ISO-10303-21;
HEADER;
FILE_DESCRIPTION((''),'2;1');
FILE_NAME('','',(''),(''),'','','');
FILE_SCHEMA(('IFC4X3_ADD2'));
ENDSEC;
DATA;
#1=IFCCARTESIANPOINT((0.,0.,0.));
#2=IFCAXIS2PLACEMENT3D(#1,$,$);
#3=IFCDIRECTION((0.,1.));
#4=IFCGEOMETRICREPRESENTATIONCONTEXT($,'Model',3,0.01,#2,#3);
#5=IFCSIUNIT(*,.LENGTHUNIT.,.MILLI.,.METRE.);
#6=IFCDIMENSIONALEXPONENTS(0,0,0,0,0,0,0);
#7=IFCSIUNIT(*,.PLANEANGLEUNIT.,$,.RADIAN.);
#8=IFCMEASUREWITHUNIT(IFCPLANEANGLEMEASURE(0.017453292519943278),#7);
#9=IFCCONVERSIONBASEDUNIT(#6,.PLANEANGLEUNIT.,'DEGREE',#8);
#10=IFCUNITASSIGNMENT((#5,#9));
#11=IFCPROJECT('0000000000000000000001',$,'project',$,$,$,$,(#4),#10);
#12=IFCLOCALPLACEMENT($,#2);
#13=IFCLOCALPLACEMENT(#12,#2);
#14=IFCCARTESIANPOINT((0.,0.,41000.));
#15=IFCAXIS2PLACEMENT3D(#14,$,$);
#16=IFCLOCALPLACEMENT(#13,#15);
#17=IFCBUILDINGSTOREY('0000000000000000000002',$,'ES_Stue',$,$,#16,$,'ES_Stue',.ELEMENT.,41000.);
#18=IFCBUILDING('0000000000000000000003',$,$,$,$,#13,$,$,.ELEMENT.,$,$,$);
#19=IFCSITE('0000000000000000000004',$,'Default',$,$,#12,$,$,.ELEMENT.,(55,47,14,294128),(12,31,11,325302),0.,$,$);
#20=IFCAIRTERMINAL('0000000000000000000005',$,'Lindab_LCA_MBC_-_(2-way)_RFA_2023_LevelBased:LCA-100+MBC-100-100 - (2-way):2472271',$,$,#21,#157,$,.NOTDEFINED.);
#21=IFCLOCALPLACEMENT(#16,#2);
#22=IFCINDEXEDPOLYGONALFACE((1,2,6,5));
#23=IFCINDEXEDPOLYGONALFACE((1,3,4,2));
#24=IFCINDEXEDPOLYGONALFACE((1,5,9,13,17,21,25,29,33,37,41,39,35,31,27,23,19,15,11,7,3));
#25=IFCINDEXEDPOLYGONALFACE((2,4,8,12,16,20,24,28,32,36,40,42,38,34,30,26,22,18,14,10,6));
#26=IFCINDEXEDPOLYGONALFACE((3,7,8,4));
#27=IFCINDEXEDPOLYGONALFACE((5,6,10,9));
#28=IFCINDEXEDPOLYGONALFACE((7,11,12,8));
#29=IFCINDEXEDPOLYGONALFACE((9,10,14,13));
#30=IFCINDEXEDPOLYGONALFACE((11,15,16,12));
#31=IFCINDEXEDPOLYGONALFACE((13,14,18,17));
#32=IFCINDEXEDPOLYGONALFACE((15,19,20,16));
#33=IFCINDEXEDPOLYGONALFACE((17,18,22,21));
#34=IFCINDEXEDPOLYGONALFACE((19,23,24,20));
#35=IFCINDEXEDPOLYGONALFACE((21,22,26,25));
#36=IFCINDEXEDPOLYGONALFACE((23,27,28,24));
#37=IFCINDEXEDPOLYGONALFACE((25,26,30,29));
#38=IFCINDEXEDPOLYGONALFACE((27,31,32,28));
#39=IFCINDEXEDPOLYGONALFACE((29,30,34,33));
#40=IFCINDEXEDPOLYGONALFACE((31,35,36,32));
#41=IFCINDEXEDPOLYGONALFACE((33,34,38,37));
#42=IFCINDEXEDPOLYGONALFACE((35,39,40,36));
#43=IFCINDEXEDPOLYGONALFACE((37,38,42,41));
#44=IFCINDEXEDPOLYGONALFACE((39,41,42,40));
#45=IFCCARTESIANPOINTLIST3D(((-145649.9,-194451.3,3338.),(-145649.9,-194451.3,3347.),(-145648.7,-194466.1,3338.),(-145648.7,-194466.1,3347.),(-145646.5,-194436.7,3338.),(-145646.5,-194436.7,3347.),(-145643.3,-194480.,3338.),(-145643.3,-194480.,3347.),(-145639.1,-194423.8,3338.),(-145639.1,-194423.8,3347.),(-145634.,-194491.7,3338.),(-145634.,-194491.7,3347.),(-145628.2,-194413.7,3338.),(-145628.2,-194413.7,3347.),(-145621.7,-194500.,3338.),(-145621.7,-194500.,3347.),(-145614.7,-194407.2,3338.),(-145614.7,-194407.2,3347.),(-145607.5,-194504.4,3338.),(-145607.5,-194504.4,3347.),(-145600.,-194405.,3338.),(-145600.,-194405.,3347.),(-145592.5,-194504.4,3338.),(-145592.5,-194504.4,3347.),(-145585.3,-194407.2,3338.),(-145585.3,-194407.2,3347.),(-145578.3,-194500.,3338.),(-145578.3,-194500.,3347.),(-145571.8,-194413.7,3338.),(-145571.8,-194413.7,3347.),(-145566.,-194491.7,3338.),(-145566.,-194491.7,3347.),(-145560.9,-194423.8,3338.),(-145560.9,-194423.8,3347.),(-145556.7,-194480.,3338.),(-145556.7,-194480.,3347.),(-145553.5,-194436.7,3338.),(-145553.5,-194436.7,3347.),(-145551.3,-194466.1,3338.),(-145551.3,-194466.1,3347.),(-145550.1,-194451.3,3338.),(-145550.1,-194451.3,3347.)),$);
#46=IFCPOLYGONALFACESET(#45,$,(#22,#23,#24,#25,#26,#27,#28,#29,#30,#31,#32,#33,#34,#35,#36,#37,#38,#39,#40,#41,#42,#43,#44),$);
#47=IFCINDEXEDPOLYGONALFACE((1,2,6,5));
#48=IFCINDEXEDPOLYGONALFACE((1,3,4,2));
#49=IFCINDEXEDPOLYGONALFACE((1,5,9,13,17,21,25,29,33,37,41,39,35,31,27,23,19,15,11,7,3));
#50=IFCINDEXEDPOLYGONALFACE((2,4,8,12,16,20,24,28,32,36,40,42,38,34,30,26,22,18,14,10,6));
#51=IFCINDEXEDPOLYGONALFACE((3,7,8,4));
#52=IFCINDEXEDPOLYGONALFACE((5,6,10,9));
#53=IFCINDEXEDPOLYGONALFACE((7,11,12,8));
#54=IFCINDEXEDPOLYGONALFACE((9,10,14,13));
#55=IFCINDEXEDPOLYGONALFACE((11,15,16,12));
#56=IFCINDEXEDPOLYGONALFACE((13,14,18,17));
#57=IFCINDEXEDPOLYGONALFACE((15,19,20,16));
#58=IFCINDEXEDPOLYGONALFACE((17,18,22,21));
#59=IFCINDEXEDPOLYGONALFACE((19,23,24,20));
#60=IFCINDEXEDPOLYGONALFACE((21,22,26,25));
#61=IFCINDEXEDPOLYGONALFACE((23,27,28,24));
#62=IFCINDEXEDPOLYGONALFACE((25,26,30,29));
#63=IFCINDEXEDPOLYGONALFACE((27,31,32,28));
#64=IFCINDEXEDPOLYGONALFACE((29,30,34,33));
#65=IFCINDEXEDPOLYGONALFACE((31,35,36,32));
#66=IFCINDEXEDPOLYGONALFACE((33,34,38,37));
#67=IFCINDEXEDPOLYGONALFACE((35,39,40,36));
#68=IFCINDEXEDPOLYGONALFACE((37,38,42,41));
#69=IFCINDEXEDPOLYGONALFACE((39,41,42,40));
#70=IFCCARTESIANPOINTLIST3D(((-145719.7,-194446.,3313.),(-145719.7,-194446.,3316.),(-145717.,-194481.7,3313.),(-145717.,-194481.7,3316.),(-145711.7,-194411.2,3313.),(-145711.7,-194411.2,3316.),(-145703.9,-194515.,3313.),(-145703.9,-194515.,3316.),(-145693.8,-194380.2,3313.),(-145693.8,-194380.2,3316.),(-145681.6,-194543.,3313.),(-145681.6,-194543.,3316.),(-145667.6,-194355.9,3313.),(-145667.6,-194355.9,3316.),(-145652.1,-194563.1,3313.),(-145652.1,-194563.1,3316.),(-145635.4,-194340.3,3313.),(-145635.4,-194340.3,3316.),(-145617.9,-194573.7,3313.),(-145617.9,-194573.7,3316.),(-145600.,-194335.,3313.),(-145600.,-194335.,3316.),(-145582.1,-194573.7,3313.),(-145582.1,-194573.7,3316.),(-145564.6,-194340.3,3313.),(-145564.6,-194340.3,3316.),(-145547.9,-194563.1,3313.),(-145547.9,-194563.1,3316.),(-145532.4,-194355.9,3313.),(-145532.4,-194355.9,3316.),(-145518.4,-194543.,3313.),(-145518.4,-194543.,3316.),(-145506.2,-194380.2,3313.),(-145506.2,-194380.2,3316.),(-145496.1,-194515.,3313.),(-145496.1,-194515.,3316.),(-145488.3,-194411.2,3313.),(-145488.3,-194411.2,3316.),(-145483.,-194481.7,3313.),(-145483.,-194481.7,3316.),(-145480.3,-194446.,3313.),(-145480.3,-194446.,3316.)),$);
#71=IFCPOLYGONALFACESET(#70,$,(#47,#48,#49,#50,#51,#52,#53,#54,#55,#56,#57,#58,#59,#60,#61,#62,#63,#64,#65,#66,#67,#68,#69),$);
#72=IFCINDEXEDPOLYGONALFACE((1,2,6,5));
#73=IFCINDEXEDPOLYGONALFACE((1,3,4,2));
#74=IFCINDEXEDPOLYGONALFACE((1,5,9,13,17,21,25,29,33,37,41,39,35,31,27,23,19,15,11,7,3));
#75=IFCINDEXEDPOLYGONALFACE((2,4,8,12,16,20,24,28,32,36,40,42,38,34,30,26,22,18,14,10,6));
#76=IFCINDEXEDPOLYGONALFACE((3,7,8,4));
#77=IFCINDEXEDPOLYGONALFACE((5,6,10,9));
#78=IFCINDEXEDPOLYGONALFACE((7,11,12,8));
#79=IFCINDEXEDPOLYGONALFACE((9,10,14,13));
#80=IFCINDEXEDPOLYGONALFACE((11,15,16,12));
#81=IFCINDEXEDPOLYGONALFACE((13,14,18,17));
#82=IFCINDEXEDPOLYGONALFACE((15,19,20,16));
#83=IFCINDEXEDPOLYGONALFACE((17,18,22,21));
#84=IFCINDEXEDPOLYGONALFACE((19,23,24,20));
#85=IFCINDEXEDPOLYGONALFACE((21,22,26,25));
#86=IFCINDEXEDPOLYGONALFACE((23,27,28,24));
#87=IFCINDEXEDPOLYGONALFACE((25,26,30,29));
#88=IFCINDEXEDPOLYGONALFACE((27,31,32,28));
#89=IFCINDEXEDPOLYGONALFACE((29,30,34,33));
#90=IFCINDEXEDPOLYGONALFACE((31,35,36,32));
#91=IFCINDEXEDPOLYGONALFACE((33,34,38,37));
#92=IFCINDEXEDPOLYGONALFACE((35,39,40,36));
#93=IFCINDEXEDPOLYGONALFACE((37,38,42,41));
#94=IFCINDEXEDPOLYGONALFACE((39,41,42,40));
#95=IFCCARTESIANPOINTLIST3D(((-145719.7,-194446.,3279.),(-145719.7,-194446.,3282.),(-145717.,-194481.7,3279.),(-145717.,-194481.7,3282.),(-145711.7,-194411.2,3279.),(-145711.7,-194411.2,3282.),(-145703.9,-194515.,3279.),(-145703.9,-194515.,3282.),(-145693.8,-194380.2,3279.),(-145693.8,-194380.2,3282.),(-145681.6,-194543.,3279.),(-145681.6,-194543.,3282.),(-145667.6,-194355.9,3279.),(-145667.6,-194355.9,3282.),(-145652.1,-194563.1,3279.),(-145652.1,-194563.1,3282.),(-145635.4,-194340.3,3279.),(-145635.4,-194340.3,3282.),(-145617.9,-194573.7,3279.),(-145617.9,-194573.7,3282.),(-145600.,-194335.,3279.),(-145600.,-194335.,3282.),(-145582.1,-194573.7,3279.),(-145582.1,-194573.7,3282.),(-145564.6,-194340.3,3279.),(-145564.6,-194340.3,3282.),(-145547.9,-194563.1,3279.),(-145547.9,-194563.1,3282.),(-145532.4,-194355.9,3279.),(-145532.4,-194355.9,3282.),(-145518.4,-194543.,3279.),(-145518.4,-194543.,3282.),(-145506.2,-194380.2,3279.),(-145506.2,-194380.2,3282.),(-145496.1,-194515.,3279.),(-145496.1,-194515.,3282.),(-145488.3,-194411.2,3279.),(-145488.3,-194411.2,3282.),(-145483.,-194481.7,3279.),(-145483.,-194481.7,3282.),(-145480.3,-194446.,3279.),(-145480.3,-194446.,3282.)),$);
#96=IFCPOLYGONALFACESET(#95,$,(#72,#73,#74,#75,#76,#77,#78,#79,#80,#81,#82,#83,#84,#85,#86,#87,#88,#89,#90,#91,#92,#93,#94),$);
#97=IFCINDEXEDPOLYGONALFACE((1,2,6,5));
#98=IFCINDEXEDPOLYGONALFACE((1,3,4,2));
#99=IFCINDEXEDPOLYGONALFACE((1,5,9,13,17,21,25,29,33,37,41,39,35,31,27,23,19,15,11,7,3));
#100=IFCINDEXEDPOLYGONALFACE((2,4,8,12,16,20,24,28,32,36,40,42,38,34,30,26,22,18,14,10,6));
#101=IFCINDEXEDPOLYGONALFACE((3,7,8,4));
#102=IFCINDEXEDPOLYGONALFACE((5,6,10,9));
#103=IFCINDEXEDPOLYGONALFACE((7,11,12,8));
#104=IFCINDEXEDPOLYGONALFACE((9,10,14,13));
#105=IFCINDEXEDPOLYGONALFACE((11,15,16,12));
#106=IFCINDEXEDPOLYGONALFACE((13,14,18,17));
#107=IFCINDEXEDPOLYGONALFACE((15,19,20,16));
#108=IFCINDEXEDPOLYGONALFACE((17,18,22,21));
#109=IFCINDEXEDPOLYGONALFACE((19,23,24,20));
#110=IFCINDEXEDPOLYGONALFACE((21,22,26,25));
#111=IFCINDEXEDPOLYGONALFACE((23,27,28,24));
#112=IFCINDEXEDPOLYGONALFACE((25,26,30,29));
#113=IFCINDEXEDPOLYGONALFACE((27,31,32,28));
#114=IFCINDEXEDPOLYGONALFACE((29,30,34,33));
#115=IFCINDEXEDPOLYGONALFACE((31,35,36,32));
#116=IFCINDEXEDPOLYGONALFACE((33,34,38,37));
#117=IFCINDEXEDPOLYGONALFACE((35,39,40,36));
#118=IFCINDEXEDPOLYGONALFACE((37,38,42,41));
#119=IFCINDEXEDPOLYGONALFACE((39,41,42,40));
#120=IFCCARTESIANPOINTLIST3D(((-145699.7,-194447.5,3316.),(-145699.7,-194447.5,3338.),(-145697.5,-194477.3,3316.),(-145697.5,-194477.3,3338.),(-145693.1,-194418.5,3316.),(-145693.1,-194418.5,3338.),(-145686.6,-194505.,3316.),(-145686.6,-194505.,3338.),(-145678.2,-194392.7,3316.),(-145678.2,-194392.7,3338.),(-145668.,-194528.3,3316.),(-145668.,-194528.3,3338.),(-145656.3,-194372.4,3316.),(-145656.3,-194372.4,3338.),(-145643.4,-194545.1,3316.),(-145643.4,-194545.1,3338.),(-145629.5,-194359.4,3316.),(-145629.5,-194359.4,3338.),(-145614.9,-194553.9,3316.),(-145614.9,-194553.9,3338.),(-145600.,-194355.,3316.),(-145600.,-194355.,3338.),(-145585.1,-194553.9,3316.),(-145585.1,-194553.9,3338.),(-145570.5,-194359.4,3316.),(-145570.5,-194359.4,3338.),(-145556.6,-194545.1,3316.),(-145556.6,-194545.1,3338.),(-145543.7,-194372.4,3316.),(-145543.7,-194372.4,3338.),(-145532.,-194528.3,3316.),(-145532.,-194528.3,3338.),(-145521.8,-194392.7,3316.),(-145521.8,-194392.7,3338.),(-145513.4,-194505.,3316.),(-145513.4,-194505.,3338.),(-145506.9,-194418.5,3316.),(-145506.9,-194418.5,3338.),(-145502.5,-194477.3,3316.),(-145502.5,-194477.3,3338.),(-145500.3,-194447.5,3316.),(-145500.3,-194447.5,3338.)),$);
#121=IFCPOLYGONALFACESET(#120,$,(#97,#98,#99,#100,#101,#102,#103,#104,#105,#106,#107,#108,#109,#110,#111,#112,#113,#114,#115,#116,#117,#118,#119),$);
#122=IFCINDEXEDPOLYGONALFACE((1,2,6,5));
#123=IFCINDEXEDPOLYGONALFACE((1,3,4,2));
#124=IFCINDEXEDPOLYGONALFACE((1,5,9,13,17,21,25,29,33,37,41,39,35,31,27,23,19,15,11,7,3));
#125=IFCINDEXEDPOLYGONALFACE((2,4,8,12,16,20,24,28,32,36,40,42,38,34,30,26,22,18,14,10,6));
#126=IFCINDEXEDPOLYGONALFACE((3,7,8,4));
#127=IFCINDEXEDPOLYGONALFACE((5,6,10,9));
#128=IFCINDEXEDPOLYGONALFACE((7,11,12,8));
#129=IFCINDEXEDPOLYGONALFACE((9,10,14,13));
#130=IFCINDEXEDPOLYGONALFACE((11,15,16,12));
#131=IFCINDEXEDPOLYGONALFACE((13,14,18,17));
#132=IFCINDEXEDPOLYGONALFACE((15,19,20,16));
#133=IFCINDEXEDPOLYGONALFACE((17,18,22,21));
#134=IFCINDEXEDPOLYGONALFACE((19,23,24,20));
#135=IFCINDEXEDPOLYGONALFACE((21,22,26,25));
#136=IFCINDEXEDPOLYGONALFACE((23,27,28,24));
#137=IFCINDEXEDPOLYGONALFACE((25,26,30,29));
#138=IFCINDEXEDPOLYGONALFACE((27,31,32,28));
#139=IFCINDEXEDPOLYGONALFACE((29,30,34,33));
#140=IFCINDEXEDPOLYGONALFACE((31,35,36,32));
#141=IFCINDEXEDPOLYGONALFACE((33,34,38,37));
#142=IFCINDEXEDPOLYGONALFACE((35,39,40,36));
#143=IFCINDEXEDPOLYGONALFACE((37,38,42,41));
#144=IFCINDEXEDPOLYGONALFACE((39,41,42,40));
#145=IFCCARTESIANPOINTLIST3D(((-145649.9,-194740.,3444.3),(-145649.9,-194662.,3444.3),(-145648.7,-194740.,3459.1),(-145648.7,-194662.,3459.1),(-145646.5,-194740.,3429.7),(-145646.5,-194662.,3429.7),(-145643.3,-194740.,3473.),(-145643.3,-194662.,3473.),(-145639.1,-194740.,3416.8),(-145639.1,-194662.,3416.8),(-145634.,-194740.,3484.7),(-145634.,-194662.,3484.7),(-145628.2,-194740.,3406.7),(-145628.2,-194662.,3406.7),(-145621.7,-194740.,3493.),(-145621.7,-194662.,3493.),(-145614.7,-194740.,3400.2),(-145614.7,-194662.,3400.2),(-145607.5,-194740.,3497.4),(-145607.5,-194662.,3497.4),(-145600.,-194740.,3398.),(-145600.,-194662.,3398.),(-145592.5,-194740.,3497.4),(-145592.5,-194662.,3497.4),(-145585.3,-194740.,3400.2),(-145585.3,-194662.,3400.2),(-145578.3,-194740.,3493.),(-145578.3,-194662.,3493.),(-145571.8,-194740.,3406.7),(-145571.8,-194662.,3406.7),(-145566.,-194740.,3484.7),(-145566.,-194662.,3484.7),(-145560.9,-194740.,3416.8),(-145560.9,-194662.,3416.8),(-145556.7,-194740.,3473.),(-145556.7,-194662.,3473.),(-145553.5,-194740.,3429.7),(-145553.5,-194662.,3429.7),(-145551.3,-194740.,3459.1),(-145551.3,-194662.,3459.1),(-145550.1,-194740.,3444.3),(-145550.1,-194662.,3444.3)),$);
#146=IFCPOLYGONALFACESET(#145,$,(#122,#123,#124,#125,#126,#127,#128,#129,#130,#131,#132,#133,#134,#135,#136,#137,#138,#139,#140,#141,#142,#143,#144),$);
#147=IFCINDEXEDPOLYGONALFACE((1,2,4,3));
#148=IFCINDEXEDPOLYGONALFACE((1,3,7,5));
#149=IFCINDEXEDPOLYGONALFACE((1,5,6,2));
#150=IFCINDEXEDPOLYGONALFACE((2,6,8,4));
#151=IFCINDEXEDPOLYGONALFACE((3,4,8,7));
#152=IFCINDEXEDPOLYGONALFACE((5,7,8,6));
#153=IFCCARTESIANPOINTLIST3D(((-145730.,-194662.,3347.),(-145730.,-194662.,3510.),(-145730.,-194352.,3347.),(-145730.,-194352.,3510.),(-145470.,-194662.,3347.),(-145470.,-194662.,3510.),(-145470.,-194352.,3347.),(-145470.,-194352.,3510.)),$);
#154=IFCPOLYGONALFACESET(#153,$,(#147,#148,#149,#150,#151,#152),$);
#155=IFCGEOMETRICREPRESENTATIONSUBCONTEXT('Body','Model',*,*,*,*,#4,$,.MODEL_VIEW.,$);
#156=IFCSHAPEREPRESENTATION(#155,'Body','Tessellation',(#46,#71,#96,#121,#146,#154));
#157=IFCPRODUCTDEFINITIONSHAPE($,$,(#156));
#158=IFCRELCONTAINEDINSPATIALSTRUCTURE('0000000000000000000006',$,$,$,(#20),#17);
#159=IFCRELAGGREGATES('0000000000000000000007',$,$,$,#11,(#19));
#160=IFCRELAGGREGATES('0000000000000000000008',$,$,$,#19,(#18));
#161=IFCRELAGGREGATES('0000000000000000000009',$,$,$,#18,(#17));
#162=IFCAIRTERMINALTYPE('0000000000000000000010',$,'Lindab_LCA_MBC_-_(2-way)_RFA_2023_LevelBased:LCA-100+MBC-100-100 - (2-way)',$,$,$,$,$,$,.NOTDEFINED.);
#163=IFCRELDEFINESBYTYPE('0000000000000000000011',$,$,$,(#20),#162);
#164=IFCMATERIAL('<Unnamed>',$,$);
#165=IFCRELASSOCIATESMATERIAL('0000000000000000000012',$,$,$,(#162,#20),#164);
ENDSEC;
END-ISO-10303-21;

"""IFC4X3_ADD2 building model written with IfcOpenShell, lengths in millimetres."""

from ifc_helpers import new_model, entity, si_unit, converted_unit, direction, frame, frame_2d, origin, origin_2d_with_axis, place, context, subcontext, project, spatial, rectangle, circle, extrude, source, transform, mapped, material, type_object, type_shapes, element, save


model = new_model("IFC4X3_ADD2")

# Units and contexts
model_context = context("Model", 3, precision=0.01, world=origin(), true_north=direction((0.0, 1.0)))
body_context = subcontext(model_context, "Body", "Model", "MODEL_VIEW")
ifc_project = project(units=[si_unit("LENGTHUNIT", "METRE", prefix="MILLI"), converted_unit("PLANEANGLEUNIT", "DEGREE", entity("IfcPlaneAngleMeasure", 0.017453292519943278), si_unit("PLANEANGLEUNIT", "RADIAN"), dimensions=[0, 0, 0, 0, 0, 0, 0])], contexts=[model_context])

# Site, building, storey
site_placement = place(None, origin())
site = spatial("IfcSite", under=ifc_project, at=site_placement, Name="Default", CompositionType="ELEMENT", RefLatitude=(55, 47, 14, 294128), RefLongitude=(12, 31, 11, 325302), RefElevation=0.0)
building_placement = place(site_placement, origin())
building = spatial("IfcBuilding", under=site, at=building_placement, CompositionType="ELEMENT")
storey_placement = place(building_placement, frame((0.0, 0.0, 41000.0)))
storey = spatial("IfcBuildingStorey", under=building, at=storey_placement, Name="ES_Stue", LongName="ES_Stue", CompositionType="ELEMENT", Elevation=41000.0)

# Air terminal
ifc_material_1 = material(Name="<Unnamed>")
air_terminal_type = type_object("IfcAirTerminalType", Name="Lindab_LCA_MBC_-_(2-way)_RFA_2023_LevelBased:LCA-100+MBC-100-100 - (2-way)", PredefinedType="NOTDEFINED", material=ifc_material_1)
shared_shape_1 = source(origin(), body_context, "Body", "SweptSolid", [
    extrude(circle(Radius=50.0, at=frame_2d((0.0, 0.0), x_axis=(1.0, 0.0))), frame((0.0, 0.0, 22.0)), (0.0, 0.0, 1.0), 9.0),
    extrude(circle(Radius=120.0, at=frame_2d((0.0, 0.0), x_axis=(1.0, 0.0))), frame((0.0, 0.0, -3.0)), (0.0, 0.0, 1.0), 3.0),
    extrude(circle(Radius=120.0, at=frame_2d((0.0, 0.0), x_axis=(1.0, 0.0))), frame((0.0, 0.0, -37.0)), (0.0, 0.0, 1.0), 3.0),
    extrude(circle(Radius=100.0, at=frame_2d((0.0, 0.0), x_axis=(1.0, 0.0))), origin(), (0.0, 0.0, 1.0), 22.0),
    extrude(circle(Radius=50.0, at=frame_2d((0.0, 0.0), x_axis=(1.0, 0.0))), frame((-285.0, 0.0, 132.0), z_axis=(1.0, 0.0, 0.0), x_axis=(0.0, 0.0, -1.0)), (0.0, 0.0, 1.0), 78.0),
    extrude(rectangle(XDim=260.0, YDim=310.0, at=origin_2d_with_axis()), frame((-52.0, 0.0, 31.0), z_axis=(0.0, 0.0, 1.0), x_axis=(0.0, -1.0, 0.0)), (0.0, 0.0, 1.0), 163.0),
])
type_shapes(air_terminal_type, [shared_shape_1])
air_terminal_placement = place(storey_placement, frame((-145600.0, -194455.0, 3316.0), z_axis=(0.0, 0.0, 1.0), x_axis=(0.0, 1.0, 0.0)))
element("IfcAirTerminal", 1, at=air_terminal_placement, inside=storey, type_object=air_terminal_type, material=ifc_material_1, Name="Lindab_LCA_MBC_-_(2-way)_RFA_2023_LevelBased:LCA-100+MBC-100-100 - (2-way):2472271", PredefinedType="NOTDEFINED", context=body_context, shape_type="MappedRepresentation", body=[
    mapped(shared_shape_1, transform((0.0, 0.0, 0.0), scale=1.0)),
])

save(model, "model.ifc")
